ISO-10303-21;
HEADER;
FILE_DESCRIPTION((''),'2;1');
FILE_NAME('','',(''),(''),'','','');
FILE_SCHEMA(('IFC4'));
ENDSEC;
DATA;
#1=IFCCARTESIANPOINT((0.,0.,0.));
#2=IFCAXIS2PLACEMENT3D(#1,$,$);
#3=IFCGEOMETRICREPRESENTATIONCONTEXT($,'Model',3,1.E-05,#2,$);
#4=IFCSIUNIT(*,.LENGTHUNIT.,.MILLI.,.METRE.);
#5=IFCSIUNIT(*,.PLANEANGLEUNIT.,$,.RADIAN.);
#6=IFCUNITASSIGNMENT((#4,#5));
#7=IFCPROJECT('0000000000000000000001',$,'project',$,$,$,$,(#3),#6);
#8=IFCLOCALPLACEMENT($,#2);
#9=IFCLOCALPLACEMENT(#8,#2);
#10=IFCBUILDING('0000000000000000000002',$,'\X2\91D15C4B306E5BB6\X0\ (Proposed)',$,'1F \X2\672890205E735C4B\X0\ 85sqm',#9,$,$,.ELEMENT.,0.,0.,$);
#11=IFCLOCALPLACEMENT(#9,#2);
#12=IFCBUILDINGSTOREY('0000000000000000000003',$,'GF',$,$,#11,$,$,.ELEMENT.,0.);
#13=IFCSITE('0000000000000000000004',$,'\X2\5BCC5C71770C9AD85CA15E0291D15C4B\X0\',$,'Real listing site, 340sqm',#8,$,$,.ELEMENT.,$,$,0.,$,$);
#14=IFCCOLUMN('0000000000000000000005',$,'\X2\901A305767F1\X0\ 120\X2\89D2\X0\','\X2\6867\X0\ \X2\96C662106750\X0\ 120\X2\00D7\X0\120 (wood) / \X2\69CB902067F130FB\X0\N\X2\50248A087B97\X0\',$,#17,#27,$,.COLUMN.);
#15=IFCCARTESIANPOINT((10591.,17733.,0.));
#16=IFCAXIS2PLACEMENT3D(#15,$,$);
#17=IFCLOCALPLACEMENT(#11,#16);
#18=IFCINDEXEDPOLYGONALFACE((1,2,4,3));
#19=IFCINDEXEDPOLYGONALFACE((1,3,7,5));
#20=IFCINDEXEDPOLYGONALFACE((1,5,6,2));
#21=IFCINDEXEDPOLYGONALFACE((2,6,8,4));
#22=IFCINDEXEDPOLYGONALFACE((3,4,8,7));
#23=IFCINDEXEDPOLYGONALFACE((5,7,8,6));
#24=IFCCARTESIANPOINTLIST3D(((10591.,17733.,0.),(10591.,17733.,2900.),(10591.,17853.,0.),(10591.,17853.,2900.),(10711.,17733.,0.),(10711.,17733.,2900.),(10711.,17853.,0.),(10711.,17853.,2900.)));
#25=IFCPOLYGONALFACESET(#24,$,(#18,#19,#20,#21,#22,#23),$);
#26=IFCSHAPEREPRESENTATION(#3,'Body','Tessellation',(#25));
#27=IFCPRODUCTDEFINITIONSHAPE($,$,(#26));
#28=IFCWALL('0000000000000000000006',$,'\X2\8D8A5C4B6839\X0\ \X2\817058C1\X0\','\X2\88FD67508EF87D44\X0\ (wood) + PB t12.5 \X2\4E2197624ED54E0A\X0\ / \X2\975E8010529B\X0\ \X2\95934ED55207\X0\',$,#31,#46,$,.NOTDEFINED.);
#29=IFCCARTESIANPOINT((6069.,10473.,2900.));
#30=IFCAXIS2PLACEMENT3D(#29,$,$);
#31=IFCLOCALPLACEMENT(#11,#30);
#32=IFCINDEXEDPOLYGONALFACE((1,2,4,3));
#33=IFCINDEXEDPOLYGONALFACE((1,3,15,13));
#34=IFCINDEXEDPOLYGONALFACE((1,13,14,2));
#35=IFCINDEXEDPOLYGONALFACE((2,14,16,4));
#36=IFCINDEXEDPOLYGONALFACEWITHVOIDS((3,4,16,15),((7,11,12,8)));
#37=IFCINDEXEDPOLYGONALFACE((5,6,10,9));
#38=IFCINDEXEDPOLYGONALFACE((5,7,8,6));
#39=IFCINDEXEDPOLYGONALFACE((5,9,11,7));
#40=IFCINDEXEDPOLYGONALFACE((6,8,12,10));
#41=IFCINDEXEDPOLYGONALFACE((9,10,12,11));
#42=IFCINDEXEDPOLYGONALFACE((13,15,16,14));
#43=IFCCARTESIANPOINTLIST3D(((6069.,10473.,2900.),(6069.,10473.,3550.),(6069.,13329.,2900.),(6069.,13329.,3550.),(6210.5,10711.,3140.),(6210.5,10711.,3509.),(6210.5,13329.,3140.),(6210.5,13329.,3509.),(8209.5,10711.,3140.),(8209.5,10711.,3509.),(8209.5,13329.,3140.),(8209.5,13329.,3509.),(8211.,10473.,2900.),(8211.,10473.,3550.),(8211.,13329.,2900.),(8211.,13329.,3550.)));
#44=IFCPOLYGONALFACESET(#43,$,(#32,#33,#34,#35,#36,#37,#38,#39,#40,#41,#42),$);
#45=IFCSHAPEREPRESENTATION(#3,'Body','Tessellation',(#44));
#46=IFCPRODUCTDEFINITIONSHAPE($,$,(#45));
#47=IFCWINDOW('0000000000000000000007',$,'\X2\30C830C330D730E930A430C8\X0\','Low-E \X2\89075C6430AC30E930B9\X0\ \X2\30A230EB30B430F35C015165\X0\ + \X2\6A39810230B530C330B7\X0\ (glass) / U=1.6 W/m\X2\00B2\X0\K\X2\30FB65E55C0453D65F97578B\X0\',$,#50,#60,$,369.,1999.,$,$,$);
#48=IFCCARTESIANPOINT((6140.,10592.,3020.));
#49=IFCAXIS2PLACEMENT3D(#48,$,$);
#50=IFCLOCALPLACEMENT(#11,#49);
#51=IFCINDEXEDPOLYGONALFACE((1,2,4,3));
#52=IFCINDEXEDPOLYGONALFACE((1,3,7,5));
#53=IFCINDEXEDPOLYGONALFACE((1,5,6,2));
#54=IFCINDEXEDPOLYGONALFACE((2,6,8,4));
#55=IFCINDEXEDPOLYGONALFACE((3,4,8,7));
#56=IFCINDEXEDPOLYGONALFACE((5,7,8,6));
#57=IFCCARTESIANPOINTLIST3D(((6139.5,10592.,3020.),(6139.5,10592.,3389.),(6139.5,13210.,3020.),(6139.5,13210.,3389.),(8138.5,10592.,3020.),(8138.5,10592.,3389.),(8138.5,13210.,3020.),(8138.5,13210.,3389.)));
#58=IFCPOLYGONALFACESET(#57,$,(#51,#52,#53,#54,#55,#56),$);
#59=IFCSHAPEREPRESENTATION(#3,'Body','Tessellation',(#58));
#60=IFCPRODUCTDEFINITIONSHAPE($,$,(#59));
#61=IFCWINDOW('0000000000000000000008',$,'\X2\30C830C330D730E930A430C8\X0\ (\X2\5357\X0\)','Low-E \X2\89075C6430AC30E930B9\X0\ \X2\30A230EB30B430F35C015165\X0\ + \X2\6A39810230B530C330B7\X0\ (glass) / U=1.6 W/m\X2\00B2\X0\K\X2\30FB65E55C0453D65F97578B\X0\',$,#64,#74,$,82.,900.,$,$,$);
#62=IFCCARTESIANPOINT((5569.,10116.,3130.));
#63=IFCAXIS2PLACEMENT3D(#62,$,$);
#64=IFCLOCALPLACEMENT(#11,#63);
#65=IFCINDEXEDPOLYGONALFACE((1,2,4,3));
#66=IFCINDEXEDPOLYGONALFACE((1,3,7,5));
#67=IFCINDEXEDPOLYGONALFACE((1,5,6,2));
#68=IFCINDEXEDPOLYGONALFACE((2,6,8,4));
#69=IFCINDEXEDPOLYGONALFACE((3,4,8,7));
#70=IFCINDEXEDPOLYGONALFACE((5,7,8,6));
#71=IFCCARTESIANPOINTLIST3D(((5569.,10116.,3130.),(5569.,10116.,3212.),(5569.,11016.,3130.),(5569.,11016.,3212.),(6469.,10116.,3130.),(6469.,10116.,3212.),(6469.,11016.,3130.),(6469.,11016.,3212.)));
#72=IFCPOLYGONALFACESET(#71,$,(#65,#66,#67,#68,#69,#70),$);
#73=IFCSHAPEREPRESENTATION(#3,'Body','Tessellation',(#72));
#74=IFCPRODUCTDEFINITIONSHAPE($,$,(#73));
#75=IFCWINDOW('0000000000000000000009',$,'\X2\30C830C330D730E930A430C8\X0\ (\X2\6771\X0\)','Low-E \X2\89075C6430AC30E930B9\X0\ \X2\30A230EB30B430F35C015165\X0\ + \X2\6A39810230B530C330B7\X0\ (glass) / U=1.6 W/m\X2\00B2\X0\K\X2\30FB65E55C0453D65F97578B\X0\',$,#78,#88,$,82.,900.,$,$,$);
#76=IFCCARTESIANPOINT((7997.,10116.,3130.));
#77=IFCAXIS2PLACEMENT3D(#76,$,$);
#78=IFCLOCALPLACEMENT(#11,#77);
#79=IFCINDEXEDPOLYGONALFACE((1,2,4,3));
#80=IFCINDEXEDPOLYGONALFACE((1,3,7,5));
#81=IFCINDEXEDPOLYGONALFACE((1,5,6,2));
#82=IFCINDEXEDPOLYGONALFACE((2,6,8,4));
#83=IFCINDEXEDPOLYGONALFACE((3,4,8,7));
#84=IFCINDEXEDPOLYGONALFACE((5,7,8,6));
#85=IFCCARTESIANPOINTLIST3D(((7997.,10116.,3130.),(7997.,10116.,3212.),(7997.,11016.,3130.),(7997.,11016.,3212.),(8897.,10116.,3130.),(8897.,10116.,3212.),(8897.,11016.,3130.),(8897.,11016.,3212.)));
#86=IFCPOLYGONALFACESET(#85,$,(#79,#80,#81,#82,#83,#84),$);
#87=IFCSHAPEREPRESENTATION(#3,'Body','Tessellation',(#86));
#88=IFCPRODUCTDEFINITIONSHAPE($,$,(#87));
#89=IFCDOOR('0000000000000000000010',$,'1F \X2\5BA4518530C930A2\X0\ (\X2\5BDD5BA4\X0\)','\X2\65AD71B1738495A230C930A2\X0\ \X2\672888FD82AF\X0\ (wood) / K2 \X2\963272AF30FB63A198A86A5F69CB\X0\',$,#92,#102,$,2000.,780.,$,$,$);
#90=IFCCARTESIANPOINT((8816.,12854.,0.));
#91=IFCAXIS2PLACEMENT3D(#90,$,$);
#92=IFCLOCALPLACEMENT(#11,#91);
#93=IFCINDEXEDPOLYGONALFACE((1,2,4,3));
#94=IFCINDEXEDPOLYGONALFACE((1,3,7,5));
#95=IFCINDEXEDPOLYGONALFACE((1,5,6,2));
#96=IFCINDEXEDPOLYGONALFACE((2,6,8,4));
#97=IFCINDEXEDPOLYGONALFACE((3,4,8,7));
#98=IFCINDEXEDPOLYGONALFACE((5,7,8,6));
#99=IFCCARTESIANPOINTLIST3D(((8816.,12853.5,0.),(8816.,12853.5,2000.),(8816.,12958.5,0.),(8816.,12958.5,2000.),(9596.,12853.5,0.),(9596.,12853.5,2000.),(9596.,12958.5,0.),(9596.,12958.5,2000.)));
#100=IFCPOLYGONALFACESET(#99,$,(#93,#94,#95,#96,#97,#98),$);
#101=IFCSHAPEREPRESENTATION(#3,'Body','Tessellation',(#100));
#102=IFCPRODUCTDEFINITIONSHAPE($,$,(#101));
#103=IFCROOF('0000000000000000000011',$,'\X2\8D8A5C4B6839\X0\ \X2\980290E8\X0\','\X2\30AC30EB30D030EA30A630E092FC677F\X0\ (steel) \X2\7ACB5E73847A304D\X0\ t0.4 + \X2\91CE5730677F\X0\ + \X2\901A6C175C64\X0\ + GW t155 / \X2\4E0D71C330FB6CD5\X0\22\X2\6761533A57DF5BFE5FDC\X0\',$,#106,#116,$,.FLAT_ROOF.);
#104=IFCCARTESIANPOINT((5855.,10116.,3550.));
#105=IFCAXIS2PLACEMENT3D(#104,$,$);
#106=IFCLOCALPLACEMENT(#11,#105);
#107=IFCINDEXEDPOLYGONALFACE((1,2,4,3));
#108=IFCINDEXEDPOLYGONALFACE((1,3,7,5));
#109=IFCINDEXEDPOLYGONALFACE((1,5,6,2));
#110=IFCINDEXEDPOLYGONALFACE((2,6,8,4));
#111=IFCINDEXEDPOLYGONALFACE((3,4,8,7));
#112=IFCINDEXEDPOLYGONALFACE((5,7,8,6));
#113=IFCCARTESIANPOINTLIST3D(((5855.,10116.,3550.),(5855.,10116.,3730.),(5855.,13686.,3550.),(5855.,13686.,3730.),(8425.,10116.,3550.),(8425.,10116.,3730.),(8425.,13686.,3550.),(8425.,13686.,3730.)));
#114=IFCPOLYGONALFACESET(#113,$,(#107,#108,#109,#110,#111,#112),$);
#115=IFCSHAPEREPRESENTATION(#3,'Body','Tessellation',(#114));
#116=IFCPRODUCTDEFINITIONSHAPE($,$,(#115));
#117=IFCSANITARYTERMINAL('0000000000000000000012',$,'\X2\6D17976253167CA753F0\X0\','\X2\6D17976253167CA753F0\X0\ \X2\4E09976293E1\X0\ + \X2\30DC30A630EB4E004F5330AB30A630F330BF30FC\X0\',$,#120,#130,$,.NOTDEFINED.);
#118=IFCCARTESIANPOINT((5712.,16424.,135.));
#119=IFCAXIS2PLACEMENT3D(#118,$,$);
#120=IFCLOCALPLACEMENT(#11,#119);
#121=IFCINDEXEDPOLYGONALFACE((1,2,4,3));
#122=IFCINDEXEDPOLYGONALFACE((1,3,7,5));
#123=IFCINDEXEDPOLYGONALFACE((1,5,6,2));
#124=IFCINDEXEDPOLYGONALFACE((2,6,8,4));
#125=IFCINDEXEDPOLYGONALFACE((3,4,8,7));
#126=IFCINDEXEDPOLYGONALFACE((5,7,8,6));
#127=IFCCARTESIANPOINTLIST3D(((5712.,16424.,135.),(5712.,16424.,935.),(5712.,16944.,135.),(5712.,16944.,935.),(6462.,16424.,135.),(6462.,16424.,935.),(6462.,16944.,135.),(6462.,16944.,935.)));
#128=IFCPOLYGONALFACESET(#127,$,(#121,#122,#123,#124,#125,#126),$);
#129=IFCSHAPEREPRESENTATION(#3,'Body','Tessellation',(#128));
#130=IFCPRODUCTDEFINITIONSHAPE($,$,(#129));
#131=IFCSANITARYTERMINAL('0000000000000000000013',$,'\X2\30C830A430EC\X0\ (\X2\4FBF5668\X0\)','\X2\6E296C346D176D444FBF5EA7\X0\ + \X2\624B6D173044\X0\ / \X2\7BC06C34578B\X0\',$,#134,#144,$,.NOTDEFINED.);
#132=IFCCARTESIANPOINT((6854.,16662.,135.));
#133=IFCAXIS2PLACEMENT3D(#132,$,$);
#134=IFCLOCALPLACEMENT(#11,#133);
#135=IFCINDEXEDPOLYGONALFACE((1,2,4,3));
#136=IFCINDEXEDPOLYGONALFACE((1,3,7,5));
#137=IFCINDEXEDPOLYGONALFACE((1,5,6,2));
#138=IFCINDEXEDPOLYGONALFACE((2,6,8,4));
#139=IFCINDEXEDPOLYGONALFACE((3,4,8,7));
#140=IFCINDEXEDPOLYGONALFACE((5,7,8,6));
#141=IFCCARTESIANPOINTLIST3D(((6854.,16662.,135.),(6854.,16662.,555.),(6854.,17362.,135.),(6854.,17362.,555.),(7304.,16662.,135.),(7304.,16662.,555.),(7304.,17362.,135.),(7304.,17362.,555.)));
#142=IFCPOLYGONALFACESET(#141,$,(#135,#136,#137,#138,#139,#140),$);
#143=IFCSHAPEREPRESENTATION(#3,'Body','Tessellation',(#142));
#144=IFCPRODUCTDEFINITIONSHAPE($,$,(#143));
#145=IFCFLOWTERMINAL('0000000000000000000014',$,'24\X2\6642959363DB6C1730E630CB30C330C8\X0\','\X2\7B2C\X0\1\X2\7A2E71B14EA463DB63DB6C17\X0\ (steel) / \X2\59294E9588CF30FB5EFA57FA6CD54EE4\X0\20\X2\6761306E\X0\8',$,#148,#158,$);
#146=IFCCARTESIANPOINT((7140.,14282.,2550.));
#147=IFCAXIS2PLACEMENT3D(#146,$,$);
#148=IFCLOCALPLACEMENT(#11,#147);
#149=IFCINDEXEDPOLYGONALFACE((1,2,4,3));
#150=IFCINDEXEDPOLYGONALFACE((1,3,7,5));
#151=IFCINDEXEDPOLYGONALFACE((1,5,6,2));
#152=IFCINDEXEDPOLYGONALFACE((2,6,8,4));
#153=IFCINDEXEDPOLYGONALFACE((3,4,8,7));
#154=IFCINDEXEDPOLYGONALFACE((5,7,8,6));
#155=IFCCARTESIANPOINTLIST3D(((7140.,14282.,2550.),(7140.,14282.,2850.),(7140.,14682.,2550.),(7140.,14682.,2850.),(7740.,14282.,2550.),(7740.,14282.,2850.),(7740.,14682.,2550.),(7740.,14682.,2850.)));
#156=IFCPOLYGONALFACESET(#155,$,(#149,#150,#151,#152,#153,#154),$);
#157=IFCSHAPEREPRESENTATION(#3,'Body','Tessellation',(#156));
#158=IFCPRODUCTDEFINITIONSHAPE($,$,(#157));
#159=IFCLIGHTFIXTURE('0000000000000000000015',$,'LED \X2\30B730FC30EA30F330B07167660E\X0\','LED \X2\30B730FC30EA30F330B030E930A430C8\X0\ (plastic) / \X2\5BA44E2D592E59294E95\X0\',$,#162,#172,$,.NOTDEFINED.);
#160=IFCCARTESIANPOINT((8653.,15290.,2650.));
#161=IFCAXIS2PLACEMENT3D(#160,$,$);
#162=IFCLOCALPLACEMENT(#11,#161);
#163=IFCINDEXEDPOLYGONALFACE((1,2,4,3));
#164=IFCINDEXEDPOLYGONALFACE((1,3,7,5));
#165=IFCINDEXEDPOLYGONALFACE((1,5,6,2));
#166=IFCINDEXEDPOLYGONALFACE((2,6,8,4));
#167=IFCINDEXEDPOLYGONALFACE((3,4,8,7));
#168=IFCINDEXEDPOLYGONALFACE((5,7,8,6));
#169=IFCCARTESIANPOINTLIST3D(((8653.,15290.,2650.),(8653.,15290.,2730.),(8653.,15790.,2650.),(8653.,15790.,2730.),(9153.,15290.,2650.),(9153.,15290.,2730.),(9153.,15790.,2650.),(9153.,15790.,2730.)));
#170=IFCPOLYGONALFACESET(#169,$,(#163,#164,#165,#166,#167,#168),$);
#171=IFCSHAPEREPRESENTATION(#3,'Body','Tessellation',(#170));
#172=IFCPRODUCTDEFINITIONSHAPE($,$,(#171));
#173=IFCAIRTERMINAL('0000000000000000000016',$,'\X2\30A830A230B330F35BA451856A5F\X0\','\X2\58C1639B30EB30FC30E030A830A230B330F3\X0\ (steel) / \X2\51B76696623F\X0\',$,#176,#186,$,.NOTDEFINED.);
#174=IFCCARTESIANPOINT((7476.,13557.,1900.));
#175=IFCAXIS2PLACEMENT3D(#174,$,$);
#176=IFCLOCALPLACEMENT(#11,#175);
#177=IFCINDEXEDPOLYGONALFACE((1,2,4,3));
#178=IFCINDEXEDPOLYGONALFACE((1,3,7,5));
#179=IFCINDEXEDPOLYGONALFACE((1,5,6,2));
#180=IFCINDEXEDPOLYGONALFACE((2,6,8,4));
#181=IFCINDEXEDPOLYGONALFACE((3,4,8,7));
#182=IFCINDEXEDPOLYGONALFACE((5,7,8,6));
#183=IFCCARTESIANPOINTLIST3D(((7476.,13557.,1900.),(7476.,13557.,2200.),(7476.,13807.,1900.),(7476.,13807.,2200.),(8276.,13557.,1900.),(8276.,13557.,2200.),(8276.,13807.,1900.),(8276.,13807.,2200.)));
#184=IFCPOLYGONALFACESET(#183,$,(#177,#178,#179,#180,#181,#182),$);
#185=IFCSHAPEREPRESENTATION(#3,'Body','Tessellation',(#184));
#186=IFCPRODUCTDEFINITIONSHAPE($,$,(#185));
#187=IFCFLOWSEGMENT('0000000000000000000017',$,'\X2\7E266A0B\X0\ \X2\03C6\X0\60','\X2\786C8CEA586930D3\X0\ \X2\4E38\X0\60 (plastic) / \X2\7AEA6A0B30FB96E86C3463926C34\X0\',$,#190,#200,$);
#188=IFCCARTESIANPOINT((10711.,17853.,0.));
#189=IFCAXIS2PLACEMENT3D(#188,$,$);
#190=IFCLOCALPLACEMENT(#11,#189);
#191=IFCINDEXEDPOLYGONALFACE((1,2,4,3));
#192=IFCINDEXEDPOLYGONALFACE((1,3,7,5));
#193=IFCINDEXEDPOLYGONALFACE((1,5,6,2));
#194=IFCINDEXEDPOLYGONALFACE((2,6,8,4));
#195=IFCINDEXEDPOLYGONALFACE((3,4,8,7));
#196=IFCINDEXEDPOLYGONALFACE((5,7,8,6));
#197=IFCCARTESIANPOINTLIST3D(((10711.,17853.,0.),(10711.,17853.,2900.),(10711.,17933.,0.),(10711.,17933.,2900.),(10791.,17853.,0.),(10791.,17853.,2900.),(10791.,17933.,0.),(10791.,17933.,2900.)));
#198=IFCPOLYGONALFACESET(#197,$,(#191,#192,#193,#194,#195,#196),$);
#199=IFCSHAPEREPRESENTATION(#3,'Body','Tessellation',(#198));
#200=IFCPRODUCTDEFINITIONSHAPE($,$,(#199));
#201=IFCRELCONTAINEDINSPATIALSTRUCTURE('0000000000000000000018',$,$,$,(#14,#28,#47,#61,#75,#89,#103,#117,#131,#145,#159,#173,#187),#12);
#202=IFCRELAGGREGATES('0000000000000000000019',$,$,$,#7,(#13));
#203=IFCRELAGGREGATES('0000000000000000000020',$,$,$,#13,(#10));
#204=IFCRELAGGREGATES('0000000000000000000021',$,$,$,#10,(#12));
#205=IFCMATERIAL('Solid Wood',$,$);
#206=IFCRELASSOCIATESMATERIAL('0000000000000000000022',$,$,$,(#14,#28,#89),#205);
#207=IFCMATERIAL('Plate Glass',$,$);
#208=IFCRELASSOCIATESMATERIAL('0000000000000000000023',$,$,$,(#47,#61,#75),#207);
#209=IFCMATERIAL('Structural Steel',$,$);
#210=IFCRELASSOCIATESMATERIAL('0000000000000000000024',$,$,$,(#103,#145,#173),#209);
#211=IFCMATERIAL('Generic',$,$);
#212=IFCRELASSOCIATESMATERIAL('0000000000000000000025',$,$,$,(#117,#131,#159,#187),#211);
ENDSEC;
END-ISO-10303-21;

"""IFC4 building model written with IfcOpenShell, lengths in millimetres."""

from ifc_helpers import new_model, si_unit, frame, frame_2d, origin, place, context, project, spatial, rectangle, extrude, material, element, fill, save


model = new_model("IFC4")

# Units and contexts
model_context = context("Model", 3, precision=1e-05, world=origin())
ifc_project = project(units=[si_unit("LENGTHUNIT", "METRE", prefix="MILLI"), si_unit("PLANEANGLEUNIT", "RADIAN")], contexts=[model_context])

# Site, building, storey
site_placement = place(None, origin())
site = spatial("IfcSite", under=ifc_project, at=site_placement, Name="富山県高岡市金屋", ObjectType="Real listing site, 340sqm", CompositionType="ELEMENT", RefElevation=0.0)
building_placement = place(site_placement, origin())
building = spatial("IfcBuilding", under=site, at=building_placement, Name="金屋の家 (Proposed)", ObjectType="1F 木造平屋 85sqm", CompositionType="ELEMENT", ElevationOfRefHeight=0.0, ElevationOfTerrain=0.0)
storey_placement = place(building_placement, origin())
storey = spatial("IfcBuildingStorey", under=building, at=storey_placement, Name="GF", CompositionType="ELEMENT", Elevation=0.0)

# Column
ifc_material_1 = material(Name="Solid Wood")
column_1_placement = place(storey_placement, frame((10591.0, 17733.0, 0.0)))
element("IfcColumn", 1, at=column_1_placement, inside=storey, material=ifc_material_1, Name="通し柱 120角", Description="桧 集成材 120×120 (wood) / 構造柱・N値計算", PredefinedType="COLUMN", context=model_context, shape_type="SweptSolid", body=[
    extrude(rectangle(XDim=120.0, YDim=120.0, at=frame_2d((60.0, 60.0))), frame((10591.0, 17733.0, 0.0)), (0.0, 0.0, 1.0), 2900.0),
])

# Wall, openings, windows
wall_1_placement = place(storey_placement, frame((6069.0, 10473.0, 2900.0)))
wall_1 = element("IfcWall", 2, at=wall_1_placement, inside=storey, material=ifc_material_1, Name="越屋根 腰壁", Description="製材軸組 (wood) + PB t12.5 両面仕上 / 非耐力 間仕切", PredefinedType="NOTDEFINED", context=model_context, shape_type="SweptSolid", body=[
    extrude(rectangle(XDim=2142.0, YDim=2856.0, at=frame_2d((1071.0, 1428.0))), frame((6069.0, 10473.0, 2900.0)), (0.0, 0.0, 1.0), 650.0),
])
opening_1_placement = place(storey_placement, frame((6140.0, 10592.0, 3020.0)))
opening_1 = element("IfcOpeningElement", 3, at=opening_1_placement, cuts=wall_1, PredefinedType="NOTDEFINED", context=model_context, shape_type="SweptSolid", body=[
    extrude(rectangle(XDim=1999.0, YDim=2618.0, at=frame_2d((999.0, 1309.0))), frame((6140.0, 10592.0, 3020.0)), (0.0, 0.0, 1.0), 369.0),
])
opening_2_placement = place(storey_placement, frame((5569.0, 10116.0, 3130.0)))
opening_2 = element("IfcOpeningElement", 4, at=opening_2_placement, cuts=wall_1, PredefinedType="NOTDEFINED", context=model_context, shape_type="SweptSolid", body=[
    extrude(rectangle(XDim=900.0, YDim=900.0, at=frame_2d((450.0, 450.0))), frame((5569.0, 10116.0, 3130.0)), (0.0, 0.0, 1.0), 82.0),
])
opening_3_placement = place(storey_placement, frame((7997.0, 10116.0, 3130.0)))
opening_3 = element("IfcOpeningElement", 5, at=opening_3_placement, cuts=wall_1, PredefinedType="NOTDEFINED", context=model_context, shape_type="SweptSolid", body=[
    extrude(rectangle(XDim=900.0, YDim=900.0, at=frame_2d((450.0, 450.0))), frame((7997.0, 10116.0, 3130.0)), (0.0, 0.0, 1.0), 82.0),
])
ifc_material_2 = material(Name="Plate Glass")
window_1_placement = place(storey_placement, frame((6140.0, 10592.0, 3020.0)))
window_1 = element("IfcWindow", 6, at=window_1_placement, inside=storey, material=ifc_material_2, Name="トップライト", Description="Low-E 複層ガラス アルゴン封入 + 樹脂サッシ (glass) / U=1.6 W/m²K・日射取得型", OverallHeight=369.0, OverallWidth=1999.0, context=model_context, shape_type="SweptSolid", body=[
    extrude(rectangle(XDim=1999.0, YDim=2618.0, at=frame_2d((999.0, 1309.0))), frame((6140.0, 10592.0, 3020.0)), (0.0, 0.0, 1.0), 369.0),
])
fill(opening_1, window_1)
window_2_placement = place(storey_placement, frame((5569.0, 10116.0, 3130.0)))
window_2 = element("IfcWindow", 7, at=window_2_placement, inside=storey, material=ifc_material_2, Name="トップライト (南)", Description="Low-E 複層ガラス アルゴン封入 + 樹脂サッシ (glass) / U=1.6 W/m²K・日射取得型", OverallHeight=82.0, OverallWidth=900.0, context=model_context, shape_type="SweptSolid", body=[
    extrude(rectangle(XDim=900.0, YDim=900.0, at=frame_2d((450.0, 450.0))), frame((5569.0, 10116.0, 3130.0)), (0.0, 0.0, 1.0), 82.0),
])
fill(opening_2, window_2)
window_3_placement = place(storey_placement, frame((7997.0, 10116.0, 3130.0)))
window_3 = element("IfcWindow", 8, at=window_3_placement, inside=storey, material=ifc_material_2, Name="トップライト (東)", Description="Low-E 複層ガラス アルゴン封入 + 樹脂サッシ (glass) / U=1.6 W/m²K・日射取得型", OverallHeight=82.0, OverallWidth=900.0, context=model_context, shape_type="SweptSolid", body=[
    extrude(rectangle(XDim=900.0, YDim=900.0, at=frame_2d((450.0, 450.0))), frame((7997.0, 10116.0, 3130.0)), (0.0, 0.0, 1.0), 82.0),
])
fill(opening_3, window_3)

# Door
door_placement = place(storey_placement, frame((8816.0, 12854.0, 0.0)))
element("IfcDoor", 9, at=door_placement, inside=storey, material=ifc_material_1, Name="1F 室内ドア (寝室)", Description="断熱玄関ドア 木製芯 (wood) / K2 防犯・採風機構", OverallHeight=2000.0, OverallWidth=780.0, context=model_context, shape_type="SweptSolid", body=[
    extrude(rectangle(XDim=780.0, YDim=105.0, at=frame_2d((390.0, 52.0))), frame((8816.0, 12854.0, 0.0)), (0.0, 0.0, 1.0), 2000.0),
])

# Roof
ifc_material_3 = material(Name="Structural Steel")
roof_placement = place(storey_placement, frame((5855.0, 10116.0, 3550.0)))
element("IfcRoof", 10, at=roof_placement, inside=storey, material=ifc_material_3, Name="越屋根 頂部", Description="ガルバリウム鋼板 (steel) 立平葺き t0.4 + 野地板 + 通気層 + GW t155 / 不燃・法22条区域対応", PredefinedType="FLAT_ROOF", context=model_context, shape_type="SweptSolid", body=[
    extrude(rectangle(XDim=2570.0, YDim=3570.0, at=frame_2d((1285.0, 1785.0))), frame((5855.0, 10116.0, 3550.0)), (0.0, 0.0, 1.0), 180.0),
])

# Sanitary terminals
ifc_material_4 = material(Name="Generic")
sanitary_terminal_1_placement = place(storey_placement, frame((5712.0, 16424.0, 135.0)))
element("IfcSanitaryTerminal", 11, at=sanitary_terminal_1_placement, inside=storey, material=ifc_material_4, Name="洗面化粧台", Description="洗面化粧台 三面鏡 + ボウル一体カウンター", PredefinedType="NOTDEFINED", context=model_context, shape_type="SweptSolid", body=[
    extrude(rectangle(XDim=750.0, YDim=520.0, at=frame_2d((375.0, 260.0))), frame((5712.0, 16424.0, 135.0)), (0.0, 0.0, 1.0), 800.0),
])
sanitary_terminal_2_placement = place(storey_placement, frame((6854.0, 16662.0, 135.0)))
element("IfcSanitaryTerminal", 12, at=sanitary_terminal_2_placement, inside=storey, material=ifc_material_4, Name="トイレ (便器)", Description="温水洗浄便座 + 手洗い / 節水型", PredefinedType="NOTDEFINED", context=model_context, shape_type="SweptSolid", body=[
    extrude(rectangle(XDim=450.0, YDim=700.0, at=frame_2d((225.0, 350.0))), frame((6854.0, 16662.0, 135.0)), (0.0, 0.0, 1.0), 420.0),
])

# Flow terminal
flow_terminal_placement = place(storey_placement, frame((7140.0, 14282.0, 2550.0)))
element("IfcFlowTerminal", 13, at=flow_terminal_placement, inside=storey, material=ifc_material_3, Name="24時間換気ユニット", Description="第1種熱交換換気 (steel) / 天井裏・建基法令20条の8", context=model_context, shape_type="SweptSolid", body=[
    extrude(rectangle(XDim=600.0, YDim=400.0, at=frame_2d((300.0, 200.0))), frame((7140.0, 14282.0, 2550.0)), (0.0, 0.0, 1.0), 300.0),
])

# Light fixture
light_fixture_placement = place(storey_placement, frame((8653.0, 15290.0, 2650.0)))
element("IfcLightFixture", 14, at=light_fixture_placement, inside=storey, material=ifc_material_4, Name="LED シーリング照明", Description="LED シーリングライト (plastic) / 室中央天井", PredefinedType="NOTDEFINED", context=model_context, shape_type="SweptSolid", body=[
    extrude(rectangle(XDim=500.0, YDim=500.0, at=frame_2d((250.0, 250.0))), frame((8653.0, 15290.0, 2650.0)), (0.0, 0.0, 1.0), 80.0),
])

# Air terminal
air_terminal_placement = place(storey_placement, frame((7476.0, 13557.0, 1900.0)))
element("IfcAirTerminal", 15, at=air_terminal_placement, inside=storey, material=ifc_material_3, Name="エアコン室内機", Description="壁掛ルームエアコン (steel) / 冷暖房", PredefinedType="NOTDEFINED", context=model_context, shape_type="SweptSolid", body=[
    extrude(rectangle(XDim=800.0, YDim=250.0, at=frame_2d((400.0, 125.0))), frame((7476.0, 13557.0, 1900.0)), (0.0, 0.0, 1.0), 300.0),
])

# Flow segment
flow_segment_placement = place(storey_placement, frame((10711.0, 17853.0, 0.0)))
element("IfcFlowSegment", 16, at=flow_segment_placement, inside=storey, material=ifc_material_4, Name="縦樋 φ60", Description="硬質塩ビ 丸60 (plastic) / 竪樋・雨水排水", context=model_context, shape_type="SweptSolid", body=[
    extrude(rectangle(XDim=80.0, YDim=80.0, at=frame_2d((40.0, 40.0))), frame((10711.0, 17853.0, 0.0)), (0.0, 0.0, 1.0), 2900.0),
])

save(model, "model.ifc")
